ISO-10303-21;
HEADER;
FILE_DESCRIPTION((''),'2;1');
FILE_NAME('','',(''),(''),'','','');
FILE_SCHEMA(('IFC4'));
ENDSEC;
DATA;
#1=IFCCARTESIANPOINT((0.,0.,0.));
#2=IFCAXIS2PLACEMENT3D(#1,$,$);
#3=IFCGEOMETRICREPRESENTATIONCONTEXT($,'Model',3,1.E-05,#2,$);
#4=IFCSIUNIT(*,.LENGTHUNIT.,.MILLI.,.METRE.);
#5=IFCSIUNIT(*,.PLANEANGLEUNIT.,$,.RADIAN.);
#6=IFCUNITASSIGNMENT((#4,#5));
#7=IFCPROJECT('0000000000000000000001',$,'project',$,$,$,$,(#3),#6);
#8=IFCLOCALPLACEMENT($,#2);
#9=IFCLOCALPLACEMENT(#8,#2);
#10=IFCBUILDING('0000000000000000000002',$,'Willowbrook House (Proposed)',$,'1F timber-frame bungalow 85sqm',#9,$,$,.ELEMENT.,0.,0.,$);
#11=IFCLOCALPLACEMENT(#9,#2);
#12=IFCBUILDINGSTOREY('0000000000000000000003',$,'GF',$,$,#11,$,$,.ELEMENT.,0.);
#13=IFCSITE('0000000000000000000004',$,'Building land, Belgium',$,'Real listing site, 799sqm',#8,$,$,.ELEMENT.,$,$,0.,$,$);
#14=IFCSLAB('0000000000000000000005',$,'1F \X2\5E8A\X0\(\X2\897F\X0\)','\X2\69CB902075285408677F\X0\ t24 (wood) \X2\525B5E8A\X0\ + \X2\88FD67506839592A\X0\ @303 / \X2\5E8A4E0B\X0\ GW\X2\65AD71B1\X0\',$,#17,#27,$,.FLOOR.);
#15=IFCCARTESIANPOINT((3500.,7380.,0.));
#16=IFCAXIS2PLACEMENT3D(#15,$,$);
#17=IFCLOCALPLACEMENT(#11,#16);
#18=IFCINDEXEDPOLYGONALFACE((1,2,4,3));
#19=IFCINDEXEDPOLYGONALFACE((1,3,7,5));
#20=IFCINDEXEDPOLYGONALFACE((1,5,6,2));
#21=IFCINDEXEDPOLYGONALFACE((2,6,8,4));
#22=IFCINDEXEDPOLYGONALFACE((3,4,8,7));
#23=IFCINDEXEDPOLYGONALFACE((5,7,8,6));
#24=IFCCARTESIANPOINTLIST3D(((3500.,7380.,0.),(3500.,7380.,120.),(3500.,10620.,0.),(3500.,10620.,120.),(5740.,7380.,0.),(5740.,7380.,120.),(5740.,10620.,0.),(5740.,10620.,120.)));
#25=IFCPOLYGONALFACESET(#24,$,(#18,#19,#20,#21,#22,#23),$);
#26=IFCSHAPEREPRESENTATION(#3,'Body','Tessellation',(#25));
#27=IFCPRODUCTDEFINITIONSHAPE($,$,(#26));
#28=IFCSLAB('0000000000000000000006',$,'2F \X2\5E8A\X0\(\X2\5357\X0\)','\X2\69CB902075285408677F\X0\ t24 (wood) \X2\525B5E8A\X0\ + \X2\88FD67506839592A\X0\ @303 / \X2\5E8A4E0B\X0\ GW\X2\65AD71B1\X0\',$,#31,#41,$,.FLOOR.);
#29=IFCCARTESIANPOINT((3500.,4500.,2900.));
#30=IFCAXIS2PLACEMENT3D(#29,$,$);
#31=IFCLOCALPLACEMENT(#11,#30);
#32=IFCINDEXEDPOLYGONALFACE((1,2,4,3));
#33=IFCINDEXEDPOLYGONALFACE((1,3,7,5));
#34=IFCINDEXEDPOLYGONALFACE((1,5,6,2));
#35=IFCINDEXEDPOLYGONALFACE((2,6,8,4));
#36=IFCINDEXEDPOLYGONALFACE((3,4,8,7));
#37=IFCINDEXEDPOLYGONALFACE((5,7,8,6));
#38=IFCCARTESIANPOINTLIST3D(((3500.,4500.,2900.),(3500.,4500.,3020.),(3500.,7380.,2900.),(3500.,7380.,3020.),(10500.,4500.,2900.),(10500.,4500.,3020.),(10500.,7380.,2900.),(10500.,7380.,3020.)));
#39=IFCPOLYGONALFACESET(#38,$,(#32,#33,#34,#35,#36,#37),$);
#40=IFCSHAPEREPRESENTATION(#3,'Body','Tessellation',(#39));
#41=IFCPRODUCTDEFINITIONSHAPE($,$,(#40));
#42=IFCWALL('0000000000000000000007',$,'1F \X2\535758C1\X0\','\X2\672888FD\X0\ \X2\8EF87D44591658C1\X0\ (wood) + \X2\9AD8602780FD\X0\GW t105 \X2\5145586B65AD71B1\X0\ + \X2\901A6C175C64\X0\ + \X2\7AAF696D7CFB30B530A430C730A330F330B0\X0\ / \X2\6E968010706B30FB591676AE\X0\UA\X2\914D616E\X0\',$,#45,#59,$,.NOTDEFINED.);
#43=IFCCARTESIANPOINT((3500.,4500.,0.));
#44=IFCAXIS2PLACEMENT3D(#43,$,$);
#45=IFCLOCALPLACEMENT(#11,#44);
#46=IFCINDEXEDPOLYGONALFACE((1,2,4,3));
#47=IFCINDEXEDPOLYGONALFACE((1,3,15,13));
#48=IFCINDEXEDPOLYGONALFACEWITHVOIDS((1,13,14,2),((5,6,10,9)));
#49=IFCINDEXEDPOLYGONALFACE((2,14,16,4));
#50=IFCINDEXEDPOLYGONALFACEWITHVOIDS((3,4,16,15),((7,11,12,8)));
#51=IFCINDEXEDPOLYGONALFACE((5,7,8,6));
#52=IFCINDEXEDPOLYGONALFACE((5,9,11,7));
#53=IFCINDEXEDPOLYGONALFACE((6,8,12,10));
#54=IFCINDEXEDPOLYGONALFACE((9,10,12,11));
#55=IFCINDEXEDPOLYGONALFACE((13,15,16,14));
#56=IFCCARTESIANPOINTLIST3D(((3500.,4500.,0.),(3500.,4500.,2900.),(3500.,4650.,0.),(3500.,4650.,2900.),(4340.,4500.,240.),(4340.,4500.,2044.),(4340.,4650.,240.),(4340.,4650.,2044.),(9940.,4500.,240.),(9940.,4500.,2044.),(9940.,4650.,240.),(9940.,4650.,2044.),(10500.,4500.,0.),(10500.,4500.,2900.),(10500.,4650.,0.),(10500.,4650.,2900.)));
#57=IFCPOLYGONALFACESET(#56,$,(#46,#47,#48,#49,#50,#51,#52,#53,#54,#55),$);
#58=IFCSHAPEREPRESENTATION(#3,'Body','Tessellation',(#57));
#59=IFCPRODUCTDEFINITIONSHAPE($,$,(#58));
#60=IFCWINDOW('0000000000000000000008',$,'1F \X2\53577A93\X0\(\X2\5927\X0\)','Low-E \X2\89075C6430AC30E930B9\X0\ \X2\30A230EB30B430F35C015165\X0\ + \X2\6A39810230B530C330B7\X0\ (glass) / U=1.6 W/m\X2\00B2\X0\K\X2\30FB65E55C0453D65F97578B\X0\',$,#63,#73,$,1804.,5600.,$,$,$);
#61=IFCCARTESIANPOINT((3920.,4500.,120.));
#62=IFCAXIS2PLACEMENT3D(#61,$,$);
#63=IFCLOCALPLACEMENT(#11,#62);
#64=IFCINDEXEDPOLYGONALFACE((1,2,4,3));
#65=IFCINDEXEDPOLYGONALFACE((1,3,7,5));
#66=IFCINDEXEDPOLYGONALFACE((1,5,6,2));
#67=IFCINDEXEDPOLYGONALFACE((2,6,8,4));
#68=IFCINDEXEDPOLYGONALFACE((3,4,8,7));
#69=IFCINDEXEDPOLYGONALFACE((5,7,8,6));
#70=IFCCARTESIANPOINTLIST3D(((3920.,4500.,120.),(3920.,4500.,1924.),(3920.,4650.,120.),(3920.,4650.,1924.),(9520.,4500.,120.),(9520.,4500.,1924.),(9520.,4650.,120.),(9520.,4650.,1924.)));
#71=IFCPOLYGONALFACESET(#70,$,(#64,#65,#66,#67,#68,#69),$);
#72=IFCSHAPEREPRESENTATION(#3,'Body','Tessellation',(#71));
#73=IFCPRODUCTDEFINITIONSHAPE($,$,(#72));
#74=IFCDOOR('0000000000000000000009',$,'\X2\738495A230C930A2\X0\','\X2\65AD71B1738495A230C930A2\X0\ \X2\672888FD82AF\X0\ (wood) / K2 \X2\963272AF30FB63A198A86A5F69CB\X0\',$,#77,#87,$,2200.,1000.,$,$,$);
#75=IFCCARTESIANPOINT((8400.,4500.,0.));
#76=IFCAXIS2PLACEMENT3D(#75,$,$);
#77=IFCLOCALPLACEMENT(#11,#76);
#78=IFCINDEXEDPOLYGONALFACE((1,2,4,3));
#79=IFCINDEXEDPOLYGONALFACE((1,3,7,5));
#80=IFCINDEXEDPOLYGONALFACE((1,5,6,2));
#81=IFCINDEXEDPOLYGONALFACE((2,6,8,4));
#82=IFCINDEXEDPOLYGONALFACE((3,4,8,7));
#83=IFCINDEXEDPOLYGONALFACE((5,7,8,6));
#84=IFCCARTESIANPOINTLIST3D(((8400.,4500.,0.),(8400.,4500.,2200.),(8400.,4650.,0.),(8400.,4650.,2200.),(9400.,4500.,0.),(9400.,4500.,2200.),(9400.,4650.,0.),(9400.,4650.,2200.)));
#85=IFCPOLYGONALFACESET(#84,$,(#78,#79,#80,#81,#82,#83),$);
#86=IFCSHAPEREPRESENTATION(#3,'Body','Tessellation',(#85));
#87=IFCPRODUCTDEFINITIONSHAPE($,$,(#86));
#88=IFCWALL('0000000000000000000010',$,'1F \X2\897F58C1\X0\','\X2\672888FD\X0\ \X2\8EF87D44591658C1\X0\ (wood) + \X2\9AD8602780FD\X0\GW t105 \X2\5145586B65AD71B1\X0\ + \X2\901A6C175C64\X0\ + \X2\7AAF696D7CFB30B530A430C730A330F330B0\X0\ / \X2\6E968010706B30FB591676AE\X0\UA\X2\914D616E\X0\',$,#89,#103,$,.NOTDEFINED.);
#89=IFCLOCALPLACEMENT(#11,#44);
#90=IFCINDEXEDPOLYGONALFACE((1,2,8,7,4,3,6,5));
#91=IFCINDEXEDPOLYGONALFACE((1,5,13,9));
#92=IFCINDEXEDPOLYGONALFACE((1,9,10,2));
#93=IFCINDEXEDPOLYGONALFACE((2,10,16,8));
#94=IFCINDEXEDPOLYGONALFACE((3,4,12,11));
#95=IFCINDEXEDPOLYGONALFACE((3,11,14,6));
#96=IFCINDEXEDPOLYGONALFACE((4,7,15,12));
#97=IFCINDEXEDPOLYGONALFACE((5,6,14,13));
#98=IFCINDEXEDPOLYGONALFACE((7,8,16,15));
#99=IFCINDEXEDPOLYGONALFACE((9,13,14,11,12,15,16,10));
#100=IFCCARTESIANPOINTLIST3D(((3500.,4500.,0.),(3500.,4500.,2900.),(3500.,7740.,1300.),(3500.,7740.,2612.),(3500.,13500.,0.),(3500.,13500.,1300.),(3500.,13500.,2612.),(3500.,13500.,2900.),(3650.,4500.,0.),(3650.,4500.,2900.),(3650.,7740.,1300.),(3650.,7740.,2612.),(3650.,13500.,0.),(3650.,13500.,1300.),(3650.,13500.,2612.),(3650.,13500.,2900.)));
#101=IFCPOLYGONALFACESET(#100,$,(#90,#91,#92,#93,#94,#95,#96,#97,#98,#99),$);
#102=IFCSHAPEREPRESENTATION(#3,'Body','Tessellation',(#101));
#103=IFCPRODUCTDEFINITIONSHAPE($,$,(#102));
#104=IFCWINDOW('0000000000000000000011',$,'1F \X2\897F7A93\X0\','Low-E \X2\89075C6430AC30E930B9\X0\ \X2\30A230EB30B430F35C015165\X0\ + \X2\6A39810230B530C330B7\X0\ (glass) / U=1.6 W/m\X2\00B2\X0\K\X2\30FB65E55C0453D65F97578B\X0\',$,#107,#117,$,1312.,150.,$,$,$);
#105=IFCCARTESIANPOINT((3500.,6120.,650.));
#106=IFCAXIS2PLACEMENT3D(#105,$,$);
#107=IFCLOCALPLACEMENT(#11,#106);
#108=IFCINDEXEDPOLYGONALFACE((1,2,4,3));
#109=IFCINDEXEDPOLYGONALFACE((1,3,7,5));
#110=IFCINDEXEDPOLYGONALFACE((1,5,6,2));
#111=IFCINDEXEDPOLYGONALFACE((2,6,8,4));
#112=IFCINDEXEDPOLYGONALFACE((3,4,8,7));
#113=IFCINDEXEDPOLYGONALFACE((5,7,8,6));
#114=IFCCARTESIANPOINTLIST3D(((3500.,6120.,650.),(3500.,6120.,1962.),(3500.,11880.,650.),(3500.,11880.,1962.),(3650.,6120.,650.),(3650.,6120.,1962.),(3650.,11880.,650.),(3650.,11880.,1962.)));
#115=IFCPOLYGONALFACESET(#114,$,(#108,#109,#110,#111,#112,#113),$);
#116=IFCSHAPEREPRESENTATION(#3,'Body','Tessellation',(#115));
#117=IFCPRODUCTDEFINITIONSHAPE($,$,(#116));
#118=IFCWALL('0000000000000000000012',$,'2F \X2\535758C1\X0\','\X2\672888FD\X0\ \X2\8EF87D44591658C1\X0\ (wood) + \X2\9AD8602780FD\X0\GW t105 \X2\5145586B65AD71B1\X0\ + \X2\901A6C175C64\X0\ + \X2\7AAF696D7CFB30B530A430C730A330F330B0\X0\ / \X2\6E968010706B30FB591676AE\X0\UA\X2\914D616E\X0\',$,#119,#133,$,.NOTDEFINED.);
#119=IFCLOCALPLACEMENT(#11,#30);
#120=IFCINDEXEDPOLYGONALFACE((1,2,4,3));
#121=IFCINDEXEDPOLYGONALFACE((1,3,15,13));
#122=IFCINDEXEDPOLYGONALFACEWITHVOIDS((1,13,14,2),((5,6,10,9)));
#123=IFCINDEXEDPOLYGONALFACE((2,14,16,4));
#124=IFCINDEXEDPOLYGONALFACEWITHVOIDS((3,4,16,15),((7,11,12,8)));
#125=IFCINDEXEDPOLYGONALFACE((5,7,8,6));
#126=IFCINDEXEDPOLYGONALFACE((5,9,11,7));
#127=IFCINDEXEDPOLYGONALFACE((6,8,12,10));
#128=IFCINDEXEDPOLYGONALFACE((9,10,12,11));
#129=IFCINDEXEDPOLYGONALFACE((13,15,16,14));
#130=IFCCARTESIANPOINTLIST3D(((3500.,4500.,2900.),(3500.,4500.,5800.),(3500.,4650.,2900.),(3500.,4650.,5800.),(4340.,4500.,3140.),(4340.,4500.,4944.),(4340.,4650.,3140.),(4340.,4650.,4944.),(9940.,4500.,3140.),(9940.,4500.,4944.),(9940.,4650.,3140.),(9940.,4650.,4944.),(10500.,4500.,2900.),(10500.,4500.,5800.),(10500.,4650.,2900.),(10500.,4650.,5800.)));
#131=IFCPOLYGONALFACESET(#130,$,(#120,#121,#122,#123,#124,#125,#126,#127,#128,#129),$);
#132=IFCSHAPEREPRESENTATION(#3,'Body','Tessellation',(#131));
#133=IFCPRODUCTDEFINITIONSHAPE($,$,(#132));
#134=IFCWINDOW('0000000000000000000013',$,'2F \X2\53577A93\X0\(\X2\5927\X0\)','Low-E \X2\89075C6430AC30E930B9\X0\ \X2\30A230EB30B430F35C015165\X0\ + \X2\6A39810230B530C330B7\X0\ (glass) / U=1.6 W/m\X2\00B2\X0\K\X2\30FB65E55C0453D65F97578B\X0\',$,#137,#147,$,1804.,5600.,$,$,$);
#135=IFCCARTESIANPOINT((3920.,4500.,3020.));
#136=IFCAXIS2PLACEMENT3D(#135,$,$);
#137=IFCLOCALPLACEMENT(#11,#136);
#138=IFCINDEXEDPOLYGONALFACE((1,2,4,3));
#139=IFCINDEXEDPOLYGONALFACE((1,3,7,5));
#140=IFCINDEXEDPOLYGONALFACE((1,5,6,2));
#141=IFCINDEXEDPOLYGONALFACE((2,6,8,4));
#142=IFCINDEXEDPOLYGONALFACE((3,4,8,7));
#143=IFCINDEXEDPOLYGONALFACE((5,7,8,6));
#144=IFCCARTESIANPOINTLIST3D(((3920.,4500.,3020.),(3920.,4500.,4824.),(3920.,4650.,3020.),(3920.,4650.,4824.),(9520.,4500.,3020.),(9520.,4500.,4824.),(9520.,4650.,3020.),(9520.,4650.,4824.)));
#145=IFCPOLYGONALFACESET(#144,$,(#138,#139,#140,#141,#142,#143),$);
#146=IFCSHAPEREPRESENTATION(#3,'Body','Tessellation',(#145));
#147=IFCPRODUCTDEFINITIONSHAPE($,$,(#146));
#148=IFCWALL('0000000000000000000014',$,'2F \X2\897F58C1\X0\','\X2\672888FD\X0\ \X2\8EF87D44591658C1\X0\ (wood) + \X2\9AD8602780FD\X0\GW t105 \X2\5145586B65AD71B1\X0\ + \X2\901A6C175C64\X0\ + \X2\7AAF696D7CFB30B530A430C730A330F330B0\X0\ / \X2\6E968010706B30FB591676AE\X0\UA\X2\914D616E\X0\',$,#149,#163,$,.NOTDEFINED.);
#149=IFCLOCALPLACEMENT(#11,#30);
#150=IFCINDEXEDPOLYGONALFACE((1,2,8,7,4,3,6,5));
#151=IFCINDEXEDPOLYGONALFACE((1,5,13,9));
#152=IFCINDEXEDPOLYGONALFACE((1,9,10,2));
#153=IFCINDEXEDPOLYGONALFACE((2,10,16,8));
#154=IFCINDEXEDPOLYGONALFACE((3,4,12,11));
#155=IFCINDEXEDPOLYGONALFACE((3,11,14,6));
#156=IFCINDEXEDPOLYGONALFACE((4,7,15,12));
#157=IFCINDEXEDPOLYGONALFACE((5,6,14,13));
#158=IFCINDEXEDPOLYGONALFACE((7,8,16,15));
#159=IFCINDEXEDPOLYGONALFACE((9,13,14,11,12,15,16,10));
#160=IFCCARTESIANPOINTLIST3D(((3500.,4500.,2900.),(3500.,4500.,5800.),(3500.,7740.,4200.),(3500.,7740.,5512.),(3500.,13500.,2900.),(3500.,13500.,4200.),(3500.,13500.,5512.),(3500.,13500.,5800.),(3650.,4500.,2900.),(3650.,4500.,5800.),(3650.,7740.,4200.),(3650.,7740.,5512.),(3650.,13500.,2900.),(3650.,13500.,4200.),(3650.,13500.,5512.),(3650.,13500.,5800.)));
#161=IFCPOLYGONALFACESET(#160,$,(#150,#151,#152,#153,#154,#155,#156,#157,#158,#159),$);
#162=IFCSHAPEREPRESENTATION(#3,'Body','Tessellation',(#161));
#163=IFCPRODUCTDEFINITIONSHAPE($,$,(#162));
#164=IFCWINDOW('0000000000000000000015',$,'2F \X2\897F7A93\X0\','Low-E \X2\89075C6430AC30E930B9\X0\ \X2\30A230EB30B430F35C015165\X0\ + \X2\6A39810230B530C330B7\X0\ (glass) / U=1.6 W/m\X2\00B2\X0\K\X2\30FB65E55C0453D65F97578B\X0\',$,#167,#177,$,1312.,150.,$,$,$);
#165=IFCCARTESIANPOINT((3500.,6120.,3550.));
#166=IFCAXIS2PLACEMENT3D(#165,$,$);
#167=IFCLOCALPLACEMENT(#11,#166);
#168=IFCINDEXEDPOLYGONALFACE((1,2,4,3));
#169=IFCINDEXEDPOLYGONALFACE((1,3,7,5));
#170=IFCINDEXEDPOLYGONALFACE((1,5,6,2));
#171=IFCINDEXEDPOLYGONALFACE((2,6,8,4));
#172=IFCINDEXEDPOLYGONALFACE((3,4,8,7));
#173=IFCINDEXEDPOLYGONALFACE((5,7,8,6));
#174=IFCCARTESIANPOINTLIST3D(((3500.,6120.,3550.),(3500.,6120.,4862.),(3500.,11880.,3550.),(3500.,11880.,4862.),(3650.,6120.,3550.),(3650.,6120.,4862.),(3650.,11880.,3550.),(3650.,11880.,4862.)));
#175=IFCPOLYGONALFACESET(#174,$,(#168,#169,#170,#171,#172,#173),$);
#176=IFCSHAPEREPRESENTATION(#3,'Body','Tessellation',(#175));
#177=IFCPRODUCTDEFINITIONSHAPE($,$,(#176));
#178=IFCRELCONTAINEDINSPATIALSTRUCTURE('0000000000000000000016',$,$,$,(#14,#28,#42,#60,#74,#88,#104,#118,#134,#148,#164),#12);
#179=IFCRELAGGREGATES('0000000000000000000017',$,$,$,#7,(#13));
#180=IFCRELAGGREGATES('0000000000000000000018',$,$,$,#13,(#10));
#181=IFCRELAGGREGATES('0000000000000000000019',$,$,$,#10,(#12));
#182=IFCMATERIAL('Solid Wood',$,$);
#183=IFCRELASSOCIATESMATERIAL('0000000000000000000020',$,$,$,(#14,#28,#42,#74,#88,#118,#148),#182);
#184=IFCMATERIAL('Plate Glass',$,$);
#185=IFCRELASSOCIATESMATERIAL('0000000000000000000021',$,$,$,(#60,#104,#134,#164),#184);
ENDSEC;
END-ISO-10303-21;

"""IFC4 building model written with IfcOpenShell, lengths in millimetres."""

from ifc_helpers import new_model, si_unit, frame, frame_2d, origin, place, context, project, spatial, rectangle, extrude, material, element, fill, save


model = new_model("IFC4")

# Units and contexts
model_context = context("Model", 3, precision=1e-05, world=origin())
ifc_project = project(units=[si_unit("LENGTHUNIT", "METRE", prefix="MILLI"), si_unit("PLANEANGLEUNIT", "RADIAN")], contexts=[model_context])

# Site, building, storey
site_placement = place(None, origin())
site = spatial("IfcSite", under=ifc_project, at=site_placement, Name="Building land, Belgium", ObjectType="Real listing site, 799sqm", CompositionType="ELEMENT", RefElevation=0.0)
building_placement = place(site_placement, origin())
building = spatial("IfcBuilding", under=site, at=building_placement, Name="Willowbrook House (Proposed)", ObjectType="1F timber-frame bungalow 85sqm", CompositionType="ELEMENT", ElevationOfRefHeight=0.0, ElevationOfTerrain=0.0)
storey_placement = place(building_placement, origin())
storey = spatial("IfcBuildingStorey", under=building, at=storey_placement, Name="GF", CompositionType="ELEMENT", Elevation=0.0)

# Slabs
ifc_material_1 = material(Name="Solid Wood")
slab_1_placement = place(storey_placement, frame((3500.0, 7380.0, 0.0)))
element("IfcSlab", 1, at=slab_1_placement, inside=storey, material=ifc_material_1, Name="1F 床(西)", Description="構造用合板 t24 (wood) 剛床 + 製材根太 @303 / 床下 GW断熱", PredefinedType="FLOOR", context=model_context, shape_type="SweptSolid", body=[
    extrude(rectangle(XDim=2240.0, YDim=3240.0, at=frame_2d((1120.0, 1620.0))), frame((3500.0, 7380.0, 0.0)), (0.0, 0.0, 1.0), 120.0),
])
slab_2_placement = place(storey_placement, frame((3500.0, 4500.0, 2900.0)))
element("IfcSlab", 2, at=slab_2_placement, inside=storey, material=ifc_material_1, Name="2F 床(南)", Description="構造用合板 t24 (wood) 剛床 + 製材根太 @303 / 床下 GW断熱", PredefinedType="FLOOR", context=model_context, shape_type="SweptSolid", body=[
    extrude(rectangle(XDim=7000.0, YDim=2880.0, at=frame_2d((3500.0, 1440.0))), frame((3500.0, 4500.0, 2900.0)), (0.0, 0.0, 1.0), 120.0),
])

# Wall, openings, window, door
wall_1_placement = place(storey_placement, frame((3500.0, 4500.0, 0.0)))
wall_1 = element("IfcWall", 3, at=wall_1_placement, inside=storey, material=ifc_material_1, Name="1F 南壁", Description="木製 軸組外壁 (wood) + 高性能GW t105 充填断熱 + 通気層 + 窯業系サイディング / 準耐火・外皮UA配慮", PredefinedType="NOTDEFINED", context=model_context, shape_type="SweptSolid", body=[
    extrude(rectangle(XDim=7000.0, YDim=150.0, at=frame_2d((3500.0, 75.0))), frame((3500.0, 4500.0, 0.0)), (0.0, 0.0, 1.0), 2900.0),
])
opening_1_placement = place(storey_placement, frame((3920.0, 4500.0, 120.0)))
opening_1 = element("IfcOpeningElement", 4, at=opening_1_placement, cuts=wall_1, PredefinedType="NOTDEFINED", context=model_context, shape_type="SweptSolid", body=[
    extrude(rectangle(XDim=5600.0, YDim=150.0, at=frame_2d((2800.0, 75.0))), frame((3920.0, 4500.0, 120.0)), (0.0, 0.0, 1.0), 1804.0),
])
opening_2_placement = place(storey_placement, frame((8400.0, 4500.0, 0.0)))
opening_2 = element("IfcOpeningElement", 5, at=opening_2_placement, cuts=wall_1, PredefinedType="NOTDEFINED", context=model_context, shape_type="SweptSolid", body=[
    extrude(rectangle(XDim=1000.0, YDim=150.0, at=frame_2d((500.0, 75.0))), frame((8400.0, 4500.0, 0.0)), (0.0, 0.0, 1.0), 2200.0),
])
ifc_material_2 = material(Name="Plate Glass")
window_1_placement = place(storey_placement, frame((3920.0, 4500.0, 120.0)))
window_1 = element("IfcWindow", 6, at=window_1_placement, inside=storey, material=ifc_material_2, Name="1F 南窓(大)", Description="Low-E 複層ガラス アルゴン封入 + 樹脂サッシ (glass) / U=1.6 W/m²K・日射取得型", OverallHeight=1804.0, OverallWidth=5600.0, context=model_context, shape_type="SweptSolid", body=[
    extrude(rectangle(XDim=5600.0, YDim=150.0, at=frame_2d((2800.0, 75.0))), frame((3920.0, 4500.0, 120.0)), (0.0, 0.0, 1.0), 1804.0),
])
fill(opening_1, window_1)
door_placement = place(storey_placement, frame((8400.0, 4500.0, 0.0)))
door = element("IfcDoor", 7, at=door_placement, inside=storey, material=ifc_material_1, Name="玄関ドア", Description="断熱玄関ドア 木製芯 (wood) / K2 防犯・採風機構", OverallHeight=2200.0, OverallWidth=1000.0, context=model_context, shape_type="SweptSolid", body=[
    extrude(rectangle(XDim=1000.0, YDim=150.0, at=frame_2d((500.0, 75.0))), frame((8400.0, 4500.0, 0.0)), (0.0, 0.0, 1.0), 2200.0),
])
fill(opening_2, door)

# Walls, openings, windows
wall_2_placement = place(storey_placement, frame((3500.0, 4500.0, 0.0)))
wall_2 = element("IfcWall", 8, at=wall_2_placement, inside=storey, material=ifc_material_1, Name="1F 西壁", Description="木製 軸組外壁 (wood) + 高性能GW t105 充填断熱 + 通気層 + 窯業系サイディング / 準耐火・外皮UA配慮", PredefinedType="NOTDEFINED", context=model_context, shape_type="SweptSolid", body=[
    extrude(rectangle(XDim=150.0, YDim=9000.0, at=frame_2d((75.0, 4500.0))), frame((3500.0, 4500.0, 0.0)), (0.0, 0.0, 1.0), 2900.0),
])
opening_3_placement = place(storey_placement, frame((3500.0, 6120.0, 650.0)))
opening_3 = element("IfcOpeningElement", 9, at=opening_3_placement, cuts=wall_2, PredefinedType="NOTDEFINED", context=model_context, shape_type="SweptSolid", body=[
    extrude(rectangle(XDim=150.0, YDim=5760.0, at=frame_2d((75.0, 2880.0))), frame((3500.0, 6120.0, 650.0)), (0.0, 0.0, 1.0), 1312.0),
])
window_2_placement = place(storey_placement, frame((3500.0, 6120.0, 650.0)))
window_2 = element("IfcWindow", 10, at=window_2_placement, inside=storey, material=ifc_material_2, Name="1F 西窓", Description="Low-E 複層ガラス アルゴン封入 + 樹脂サッシ (glass) / U=1.6 W/m²K・日射取得型", OverallHeight=1312.0, OverallWidth=150.0, context=model_context, shape_type="SweptSolid", body=[
    extrude(rectangle(XDim=150.0, YDim=5760.0, at=frame_2d((75.0, 2880.0))), frame((3500.0, 6120.0, 650.0)), (0.0, 0.0, 1.0), 1312.0),
])
fill(opening_3, window_2)
wall_3_placement = place(storey_placement, frame((3500.0, 4500.0, 2900.0)))
wall_3 = element("IfcWall", 11, at=wall_3_placement, inside=storey, material=ifc_material_1, Name="2F 南壁", Description="木製 軸組外壁 (wood) + 高性能GW t105 充填断熱 + 通気層 + 窯業系サイディング / 準耐火・外皮UA配慮", PredefinedType="NOTDEFINED", context=model_context, shape_type="SweptSolid", body=[
    extrude(rectangle(XDim=7000.0, YDim=150.0, at=frame_2d((3500.0, 75.0))), frame((3500.0, 4500.0, 2900.0)), (0.0, 0.0, 1.0), 2900.0),
])
opening_4_placement = place(storey_placement, frame((3920.0, 4500.0, 3020.0)))
opening_4 = element("IfcOpeningElement", 12, at=opening_4_placement, cuts=wall_3, PredefinedType="NOTDEFINED", context=model_context, shape_type="SweptSolid", body=[
    extrude(rectangle(XDim=5600.0, YDim=150.0, at=frame_2d((2800.0, 75.0))), frame((3920.0, 4500.0, 3020.0)), (0.0, 0.0, 1.0), 1804.0),
])
window_3_placement = place(storey_placement, frame((3920.0, 4500.0, 3020.0)))
window_3 = element("IfcWindow", 13, at=window_3_placement, inside=storey, material=ifc_material_2, Name="2F 南窓(大)", Description="Low-E 複層ガラス アルゴン封入 + 樹脂サッシ (glass) / U=1.6 W/m²K・日射取得型", OverallHeight=1804.0, OverallWidth=5600.0, context=model_context, shape_type="SweptSolid", body=[
    extrude(rectangle(XDim=5600.0, YDim=150.0, at=frame_2d((2800.0, 75.0))), frame((3920.0, 4500.0, 3020.0)), (0.0, 0.0, 1.0), 1804.0),
])
fill(opening_4, window_3)
wall_4_placement = place(storey_placement, frame((3500.0, 4500.0, 2900.0)))
wall_4 = element("IfcWall", 14, at=wall_4_placement, inside=storey, material=ifc_material_1, Name="2F 西壁", Description="木製 軸組外壁 (wood) + 高性能GW t105 充填断熱 + 通気層 + 窯業系サイディング / 準耐火・外皮UA配慮", PredefinedType="NOTDEFINED", context=model_context, shape_type="SweptSolid", body=[
    extrude(rectangle(XDim=150.0, YDim=9000.0, at=frame_2d((75.0, 4500.0))), frame((3500.0, 4500.0, 2900.0)), (0.0, 0.0, 1.0), 2900.0),
])
opening_5_placement = place(storey_placement, frame((3500.0, 6120.0, 3550.0)))
opening_5 = element("IfcOpeningElement", 15, at=opening_5_placement, cuts=wall_4, PredefinedType="NOTDEFINED", context=model_context, shape_type="SweptSolid", body=[
    extrude(rectangle(XDim=150.0, YDim=5760.0, at=frame_2d((75.0, 2880.0))), frame((3500.0, 6120.0, 3550.0)), (0.0, 0.0, 1.0), 1312.0),
])
window_4_placement = place(storey_placement, frame((3500.0, 6120.0, 3550.0)))
window_4 = element("IfcWindow", 16, at=window_4_placement, inside=storey, material=ifc_material_2, Name="2F 西窓", Description="Low-E 複層ガラス アルゴン封入 + 樹脂サッシ (glass) / U=1.6 W/m²K・日射取得型", OverallHeight=1312.0, OverallWidth=150.0, context=model_context, shape_type="SweptSolid", body=[
    extrude(rectangle(XDim=150.0, YDim=5760.0, at=frame_2d((75.0, 2880.0))), frame((3500.0, 6120.0, 3550.0)), (0.0, 0.0, 1.0), 1312.0),
])
fill(opening_5, window_4)

save(model, "model.ifc")
